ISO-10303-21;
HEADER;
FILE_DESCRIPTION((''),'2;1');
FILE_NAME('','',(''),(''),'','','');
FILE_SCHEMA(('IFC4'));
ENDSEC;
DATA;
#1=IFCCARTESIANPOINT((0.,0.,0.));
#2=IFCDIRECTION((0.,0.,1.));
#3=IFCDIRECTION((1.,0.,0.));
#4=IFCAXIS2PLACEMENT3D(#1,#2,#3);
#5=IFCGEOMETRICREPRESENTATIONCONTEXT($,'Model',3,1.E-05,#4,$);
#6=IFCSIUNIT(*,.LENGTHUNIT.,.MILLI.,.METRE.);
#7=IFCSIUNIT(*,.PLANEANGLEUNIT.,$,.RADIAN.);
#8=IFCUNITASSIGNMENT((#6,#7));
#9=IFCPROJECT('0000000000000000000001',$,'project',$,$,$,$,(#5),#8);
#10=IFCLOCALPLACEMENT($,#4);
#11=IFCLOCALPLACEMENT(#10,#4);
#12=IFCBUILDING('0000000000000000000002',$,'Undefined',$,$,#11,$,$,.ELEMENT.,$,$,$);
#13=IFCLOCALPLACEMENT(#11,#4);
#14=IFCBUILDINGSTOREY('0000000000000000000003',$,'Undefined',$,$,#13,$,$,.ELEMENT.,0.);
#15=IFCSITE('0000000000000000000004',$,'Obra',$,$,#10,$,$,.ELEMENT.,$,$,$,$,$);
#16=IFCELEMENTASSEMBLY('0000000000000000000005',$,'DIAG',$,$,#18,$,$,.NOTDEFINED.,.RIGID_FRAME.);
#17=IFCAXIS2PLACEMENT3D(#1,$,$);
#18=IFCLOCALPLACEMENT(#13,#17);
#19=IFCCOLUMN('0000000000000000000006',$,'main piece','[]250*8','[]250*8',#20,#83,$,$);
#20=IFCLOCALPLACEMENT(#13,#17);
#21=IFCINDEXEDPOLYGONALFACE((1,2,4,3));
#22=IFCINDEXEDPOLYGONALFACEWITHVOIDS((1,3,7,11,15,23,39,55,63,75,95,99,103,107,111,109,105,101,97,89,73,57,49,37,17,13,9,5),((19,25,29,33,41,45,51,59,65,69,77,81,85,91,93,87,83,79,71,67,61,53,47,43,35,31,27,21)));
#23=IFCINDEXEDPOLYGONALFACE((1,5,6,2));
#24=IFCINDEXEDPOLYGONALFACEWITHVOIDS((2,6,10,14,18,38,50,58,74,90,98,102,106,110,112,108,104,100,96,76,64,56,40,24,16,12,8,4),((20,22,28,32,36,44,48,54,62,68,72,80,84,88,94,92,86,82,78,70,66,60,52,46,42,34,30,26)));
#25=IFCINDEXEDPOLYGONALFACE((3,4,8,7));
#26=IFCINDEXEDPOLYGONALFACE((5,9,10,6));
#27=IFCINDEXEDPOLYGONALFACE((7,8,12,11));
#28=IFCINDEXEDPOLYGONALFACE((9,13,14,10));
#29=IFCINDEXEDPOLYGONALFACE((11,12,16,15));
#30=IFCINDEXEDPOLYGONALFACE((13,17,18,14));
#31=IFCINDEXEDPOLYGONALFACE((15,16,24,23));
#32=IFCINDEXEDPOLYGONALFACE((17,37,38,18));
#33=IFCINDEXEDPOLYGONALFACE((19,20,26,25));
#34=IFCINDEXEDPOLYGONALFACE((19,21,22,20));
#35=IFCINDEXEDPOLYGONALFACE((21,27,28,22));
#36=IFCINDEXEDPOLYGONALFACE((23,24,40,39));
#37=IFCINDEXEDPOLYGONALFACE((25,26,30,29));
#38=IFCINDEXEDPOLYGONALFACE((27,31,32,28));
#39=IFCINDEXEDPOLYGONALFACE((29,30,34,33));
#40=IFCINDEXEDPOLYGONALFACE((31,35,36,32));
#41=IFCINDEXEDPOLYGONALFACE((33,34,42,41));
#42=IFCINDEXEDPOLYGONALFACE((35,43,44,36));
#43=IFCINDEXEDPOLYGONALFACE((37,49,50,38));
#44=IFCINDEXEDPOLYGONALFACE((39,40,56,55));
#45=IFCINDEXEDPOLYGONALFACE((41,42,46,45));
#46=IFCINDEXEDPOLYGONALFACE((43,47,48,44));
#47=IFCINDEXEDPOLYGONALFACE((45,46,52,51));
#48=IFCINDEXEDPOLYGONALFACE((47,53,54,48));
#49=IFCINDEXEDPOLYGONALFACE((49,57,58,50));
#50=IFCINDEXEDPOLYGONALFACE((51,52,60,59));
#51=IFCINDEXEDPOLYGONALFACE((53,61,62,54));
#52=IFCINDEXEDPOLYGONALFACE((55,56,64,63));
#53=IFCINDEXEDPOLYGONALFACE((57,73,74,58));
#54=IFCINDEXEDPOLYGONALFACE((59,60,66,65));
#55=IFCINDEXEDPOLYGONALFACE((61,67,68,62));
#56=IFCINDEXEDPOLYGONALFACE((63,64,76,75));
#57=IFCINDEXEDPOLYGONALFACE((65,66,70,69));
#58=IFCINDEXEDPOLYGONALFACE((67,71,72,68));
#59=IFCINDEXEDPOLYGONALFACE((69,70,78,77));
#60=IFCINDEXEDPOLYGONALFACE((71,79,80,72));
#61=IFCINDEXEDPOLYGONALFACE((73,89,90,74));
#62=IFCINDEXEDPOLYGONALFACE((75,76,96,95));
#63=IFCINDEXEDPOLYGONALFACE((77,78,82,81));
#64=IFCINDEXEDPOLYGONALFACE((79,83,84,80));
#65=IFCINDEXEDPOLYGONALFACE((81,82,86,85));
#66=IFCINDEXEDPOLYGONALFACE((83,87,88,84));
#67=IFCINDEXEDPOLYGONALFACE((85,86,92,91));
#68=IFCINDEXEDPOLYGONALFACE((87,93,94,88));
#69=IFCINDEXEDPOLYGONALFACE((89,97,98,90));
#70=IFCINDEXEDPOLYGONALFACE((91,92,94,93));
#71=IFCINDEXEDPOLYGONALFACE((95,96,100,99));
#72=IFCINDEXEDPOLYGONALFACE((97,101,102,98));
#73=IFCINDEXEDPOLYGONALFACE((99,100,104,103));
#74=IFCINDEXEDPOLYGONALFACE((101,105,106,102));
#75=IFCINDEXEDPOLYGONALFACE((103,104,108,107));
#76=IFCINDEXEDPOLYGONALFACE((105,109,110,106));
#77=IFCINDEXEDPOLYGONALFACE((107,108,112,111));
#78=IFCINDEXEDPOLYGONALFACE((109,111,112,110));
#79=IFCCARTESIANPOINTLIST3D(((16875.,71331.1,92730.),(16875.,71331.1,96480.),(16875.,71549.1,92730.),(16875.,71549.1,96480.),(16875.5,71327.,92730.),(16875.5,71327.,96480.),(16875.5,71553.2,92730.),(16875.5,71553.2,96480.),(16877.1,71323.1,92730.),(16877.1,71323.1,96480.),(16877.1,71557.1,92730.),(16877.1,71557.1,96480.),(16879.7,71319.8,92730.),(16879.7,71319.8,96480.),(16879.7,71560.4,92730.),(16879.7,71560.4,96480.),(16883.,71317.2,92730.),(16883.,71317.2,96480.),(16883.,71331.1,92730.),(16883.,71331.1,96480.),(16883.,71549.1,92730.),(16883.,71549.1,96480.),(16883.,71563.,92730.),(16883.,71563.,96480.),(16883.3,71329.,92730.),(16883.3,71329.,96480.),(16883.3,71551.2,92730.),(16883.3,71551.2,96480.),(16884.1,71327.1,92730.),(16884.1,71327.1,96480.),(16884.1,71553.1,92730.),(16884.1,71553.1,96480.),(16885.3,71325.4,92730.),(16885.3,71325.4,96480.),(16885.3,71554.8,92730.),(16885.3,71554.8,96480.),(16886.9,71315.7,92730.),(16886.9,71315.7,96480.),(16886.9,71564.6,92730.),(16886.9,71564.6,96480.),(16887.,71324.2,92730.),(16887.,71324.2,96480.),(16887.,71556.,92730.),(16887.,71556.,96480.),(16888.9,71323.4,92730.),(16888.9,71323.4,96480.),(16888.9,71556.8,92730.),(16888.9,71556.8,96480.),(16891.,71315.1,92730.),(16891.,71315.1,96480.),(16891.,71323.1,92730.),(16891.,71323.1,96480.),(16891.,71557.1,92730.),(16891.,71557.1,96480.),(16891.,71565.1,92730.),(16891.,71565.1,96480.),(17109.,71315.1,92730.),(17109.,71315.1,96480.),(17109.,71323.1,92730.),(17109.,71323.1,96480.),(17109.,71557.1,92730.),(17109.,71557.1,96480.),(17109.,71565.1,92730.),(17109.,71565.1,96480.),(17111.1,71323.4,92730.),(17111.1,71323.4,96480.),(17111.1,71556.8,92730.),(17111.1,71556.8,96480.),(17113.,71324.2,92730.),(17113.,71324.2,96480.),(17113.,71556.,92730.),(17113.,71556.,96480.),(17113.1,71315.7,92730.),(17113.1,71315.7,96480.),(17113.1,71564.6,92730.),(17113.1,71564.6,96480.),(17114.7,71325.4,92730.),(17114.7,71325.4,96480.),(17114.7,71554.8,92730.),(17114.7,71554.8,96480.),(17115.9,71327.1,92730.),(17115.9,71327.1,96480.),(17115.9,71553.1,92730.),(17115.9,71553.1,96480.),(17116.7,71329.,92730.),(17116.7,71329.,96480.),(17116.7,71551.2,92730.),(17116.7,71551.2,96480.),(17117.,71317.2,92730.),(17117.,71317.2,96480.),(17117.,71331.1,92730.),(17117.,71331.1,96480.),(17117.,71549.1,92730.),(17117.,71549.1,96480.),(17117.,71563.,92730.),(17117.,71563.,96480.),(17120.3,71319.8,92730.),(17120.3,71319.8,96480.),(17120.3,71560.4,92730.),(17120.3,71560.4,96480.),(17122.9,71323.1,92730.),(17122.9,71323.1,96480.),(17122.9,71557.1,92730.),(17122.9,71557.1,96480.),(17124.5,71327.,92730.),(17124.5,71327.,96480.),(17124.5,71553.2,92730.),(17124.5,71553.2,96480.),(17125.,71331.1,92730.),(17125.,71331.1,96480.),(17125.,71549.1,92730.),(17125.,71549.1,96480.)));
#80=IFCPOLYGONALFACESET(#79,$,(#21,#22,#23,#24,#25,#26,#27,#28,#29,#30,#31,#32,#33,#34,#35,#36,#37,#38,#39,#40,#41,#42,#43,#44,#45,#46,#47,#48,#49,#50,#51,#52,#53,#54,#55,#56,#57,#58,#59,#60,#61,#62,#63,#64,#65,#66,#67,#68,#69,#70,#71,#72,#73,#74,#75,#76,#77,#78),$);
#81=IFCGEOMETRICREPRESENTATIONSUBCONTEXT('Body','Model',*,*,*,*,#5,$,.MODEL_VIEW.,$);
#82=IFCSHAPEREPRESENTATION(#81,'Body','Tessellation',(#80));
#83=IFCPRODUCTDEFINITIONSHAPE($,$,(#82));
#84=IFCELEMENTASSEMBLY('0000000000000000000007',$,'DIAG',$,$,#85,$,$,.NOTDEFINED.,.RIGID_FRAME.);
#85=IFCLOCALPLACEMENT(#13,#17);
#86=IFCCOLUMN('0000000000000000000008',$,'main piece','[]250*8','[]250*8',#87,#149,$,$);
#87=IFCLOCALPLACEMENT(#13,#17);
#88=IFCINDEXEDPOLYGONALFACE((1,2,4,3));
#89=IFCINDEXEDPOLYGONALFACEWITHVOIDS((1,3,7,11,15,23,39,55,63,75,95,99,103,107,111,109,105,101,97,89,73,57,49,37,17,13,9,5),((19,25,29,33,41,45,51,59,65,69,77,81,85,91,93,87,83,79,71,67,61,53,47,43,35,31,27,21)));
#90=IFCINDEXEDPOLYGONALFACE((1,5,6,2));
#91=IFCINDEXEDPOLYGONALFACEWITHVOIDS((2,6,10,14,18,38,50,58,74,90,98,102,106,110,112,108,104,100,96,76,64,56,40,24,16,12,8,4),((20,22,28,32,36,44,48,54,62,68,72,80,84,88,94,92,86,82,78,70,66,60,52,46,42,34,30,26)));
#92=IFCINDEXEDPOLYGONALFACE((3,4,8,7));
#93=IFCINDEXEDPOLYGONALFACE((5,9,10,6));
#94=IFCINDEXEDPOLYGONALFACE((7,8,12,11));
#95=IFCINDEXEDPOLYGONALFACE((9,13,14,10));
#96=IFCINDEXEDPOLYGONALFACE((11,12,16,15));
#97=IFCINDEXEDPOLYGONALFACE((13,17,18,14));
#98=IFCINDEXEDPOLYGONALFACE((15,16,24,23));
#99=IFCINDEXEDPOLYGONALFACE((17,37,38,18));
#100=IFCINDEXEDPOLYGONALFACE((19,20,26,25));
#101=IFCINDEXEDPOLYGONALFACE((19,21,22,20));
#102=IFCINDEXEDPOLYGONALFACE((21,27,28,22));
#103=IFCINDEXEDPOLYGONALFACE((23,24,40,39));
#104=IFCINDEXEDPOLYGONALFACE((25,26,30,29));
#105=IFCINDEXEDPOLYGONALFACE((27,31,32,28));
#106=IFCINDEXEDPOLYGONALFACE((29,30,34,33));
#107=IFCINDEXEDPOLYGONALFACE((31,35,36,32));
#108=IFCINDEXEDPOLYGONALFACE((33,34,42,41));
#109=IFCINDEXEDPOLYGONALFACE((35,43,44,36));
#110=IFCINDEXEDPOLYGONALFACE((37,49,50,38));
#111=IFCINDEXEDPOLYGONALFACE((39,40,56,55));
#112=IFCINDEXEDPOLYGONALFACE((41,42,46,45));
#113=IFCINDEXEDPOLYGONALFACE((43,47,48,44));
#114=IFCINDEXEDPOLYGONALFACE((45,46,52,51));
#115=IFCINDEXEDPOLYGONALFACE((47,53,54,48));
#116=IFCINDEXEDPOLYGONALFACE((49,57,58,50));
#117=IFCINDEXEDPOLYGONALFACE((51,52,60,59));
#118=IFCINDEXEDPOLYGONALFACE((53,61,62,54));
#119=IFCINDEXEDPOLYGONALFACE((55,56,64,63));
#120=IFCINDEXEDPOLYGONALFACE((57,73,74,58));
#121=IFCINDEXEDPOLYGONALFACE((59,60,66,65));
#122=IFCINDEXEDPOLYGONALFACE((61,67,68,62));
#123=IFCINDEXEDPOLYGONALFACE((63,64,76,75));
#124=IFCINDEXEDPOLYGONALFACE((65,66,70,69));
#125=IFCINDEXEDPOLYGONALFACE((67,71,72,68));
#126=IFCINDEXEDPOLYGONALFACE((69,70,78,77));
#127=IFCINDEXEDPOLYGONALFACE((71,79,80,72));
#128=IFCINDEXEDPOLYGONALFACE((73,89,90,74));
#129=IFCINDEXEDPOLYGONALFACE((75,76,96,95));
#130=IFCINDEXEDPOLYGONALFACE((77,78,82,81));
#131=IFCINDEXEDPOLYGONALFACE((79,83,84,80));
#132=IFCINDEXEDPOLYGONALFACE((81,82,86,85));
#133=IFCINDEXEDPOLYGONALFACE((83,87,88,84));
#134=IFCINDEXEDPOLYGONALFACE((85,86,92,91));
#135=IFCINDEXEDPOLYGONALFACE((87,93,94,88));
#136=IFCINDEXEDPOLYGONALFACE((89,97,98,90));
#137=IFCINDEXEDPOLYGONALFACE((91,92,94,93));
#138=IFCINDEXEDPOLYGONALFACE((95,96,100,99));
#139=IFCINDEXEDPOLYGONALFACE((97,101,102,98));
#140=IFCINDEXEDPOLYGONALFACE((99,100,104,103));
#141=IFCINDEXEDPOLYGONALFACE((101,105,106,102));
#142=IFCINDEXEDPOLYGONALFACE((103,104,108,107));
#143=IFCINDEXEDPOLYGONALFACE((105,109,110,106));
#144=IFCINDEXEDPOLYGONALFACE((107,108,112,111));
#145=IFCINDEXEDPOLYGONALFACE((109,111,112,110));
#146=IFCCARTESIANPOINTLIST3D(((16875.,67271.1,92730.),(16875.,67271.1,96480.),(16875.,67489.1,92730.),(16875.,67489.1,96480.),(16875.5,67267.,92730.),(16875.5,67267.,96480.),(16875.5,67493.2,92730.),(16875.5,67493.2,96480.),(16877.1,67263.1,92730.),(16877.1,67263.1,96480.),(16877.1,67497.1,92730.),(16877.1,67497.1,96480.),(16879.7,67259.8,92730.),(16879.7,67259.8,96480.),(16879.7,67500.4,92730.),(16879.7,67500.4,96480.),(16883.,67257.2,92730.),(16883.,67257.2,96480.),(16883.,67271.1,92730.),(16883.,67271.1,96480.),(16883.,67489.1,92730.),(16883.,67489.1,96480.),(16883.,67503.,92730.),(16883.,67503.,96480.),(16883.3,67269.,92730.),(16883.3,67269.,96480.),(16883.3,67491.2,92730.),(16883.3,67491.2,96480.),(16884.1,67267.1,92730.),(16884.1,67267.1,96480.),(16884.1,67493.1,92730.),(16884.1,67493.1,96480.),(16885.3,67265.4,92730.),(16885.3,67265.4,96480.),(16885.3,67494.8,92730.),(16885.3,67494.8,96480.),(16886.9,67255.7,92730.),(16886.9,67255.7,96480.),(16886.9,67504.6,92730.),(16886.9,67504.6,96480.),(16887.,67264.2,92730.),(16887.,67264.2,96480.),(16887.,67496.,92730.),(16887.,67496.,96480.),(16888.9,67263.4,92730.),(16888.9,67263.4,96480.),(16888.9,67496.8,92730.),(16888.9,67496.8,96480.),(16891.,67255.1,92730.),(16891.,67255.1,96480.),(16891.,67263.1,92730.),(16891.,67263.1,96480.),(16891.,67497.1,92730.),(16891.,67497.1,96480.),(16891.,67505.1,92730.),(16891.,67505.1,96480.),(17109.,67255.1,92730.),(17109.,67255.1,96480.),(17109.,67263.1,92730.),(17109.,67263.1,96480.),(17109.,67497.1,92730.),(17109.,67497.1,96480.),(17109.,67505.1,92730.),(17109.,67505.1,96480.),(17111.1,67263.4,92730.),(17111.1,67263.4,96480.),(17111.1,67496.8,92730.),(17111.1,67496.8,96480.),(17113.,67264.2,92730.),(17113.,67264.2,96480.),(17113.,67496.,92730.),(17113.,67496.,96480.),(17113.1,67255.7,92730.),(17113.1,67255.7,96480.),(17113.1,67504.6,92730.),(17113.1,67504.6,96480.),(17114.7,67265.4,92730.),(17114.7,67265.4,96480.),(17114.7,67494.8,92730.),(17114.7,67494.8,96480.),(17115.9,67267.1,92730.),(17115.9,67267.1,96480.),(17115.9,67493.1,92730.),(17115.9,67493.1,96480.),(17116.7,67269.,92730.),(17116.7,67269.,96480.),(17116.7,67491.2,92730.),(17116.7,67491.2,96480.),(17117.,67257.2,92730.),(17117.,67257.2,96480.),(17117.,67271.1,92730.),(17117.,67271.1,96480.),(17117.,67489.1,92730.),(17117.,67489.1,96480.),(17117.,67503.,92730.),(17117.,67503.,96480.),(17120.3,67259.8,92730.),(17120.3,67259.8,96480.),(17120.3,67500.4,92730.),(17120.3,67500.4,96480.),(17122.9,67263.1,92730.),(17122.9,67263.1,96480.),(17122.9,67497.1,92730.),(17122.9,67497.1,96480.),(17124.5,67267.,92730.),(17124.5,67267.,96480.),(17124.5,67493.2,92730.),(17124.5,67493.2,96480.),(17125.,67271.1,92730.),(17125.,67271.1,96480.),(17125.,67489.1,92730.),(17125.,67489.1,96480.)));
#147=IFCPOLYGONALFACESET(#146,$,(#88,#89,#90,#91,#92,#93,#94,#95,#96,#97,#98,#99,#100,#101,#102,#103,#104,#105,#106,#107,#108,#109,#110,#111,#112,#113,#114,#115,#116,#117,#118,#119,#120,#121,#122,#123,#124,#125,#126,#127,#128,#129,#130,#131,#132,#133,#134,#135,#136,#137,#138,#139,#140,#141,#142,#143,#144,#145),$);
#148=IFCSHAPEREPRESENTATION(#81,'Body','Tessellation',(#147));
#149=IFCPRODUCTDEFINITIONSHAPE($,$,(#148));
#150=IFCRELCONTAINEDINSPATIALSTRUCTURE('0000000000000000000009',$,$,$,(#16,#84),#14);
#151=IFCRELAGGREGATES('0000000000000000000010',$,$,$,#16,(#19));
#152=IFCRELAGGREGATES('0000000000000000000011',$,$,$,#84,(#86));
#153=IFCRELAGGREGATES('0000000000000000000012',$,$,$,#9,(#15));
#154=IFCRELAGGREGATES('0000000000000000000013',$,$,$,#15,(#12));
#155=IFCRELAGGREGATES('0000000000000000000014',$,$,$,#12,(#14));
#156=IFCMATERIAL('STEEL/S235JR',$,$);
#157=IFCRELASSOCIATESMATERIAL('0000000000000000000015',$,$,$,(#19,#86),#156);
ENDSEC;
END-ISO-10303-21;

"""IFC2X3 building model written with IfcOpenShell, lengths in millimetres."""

from ifc_helpers import new_model, si_unit, frame, origin_with_axes, origin_2d_with_axis, place, context, subcontext, project, spatial, hollow_rectangle, extrude, material, element, aggregate, save


model = new_model("IFC2X3")

# Units and contexts
model_context = context("Model", 3, precision=1e-05, world=origin_with_axes())
body_context = subcontext(model_context, "Body", "Model", "MODEL_VIEW")
ifc_project = project(units=[si_unit("LENGTHUNIT", "METRE", prefix="MILLI"), si_unit("PLANEANGLEUNIT", "RADIAN")], contexts=[model_context])

# Site, building, storey
site_placement = place(None, origin_with_axes())
site = spatial("IfcSite", under=ifc_project, at=site_placement, Name="Obra", CompositionType="ELEMENT")
building_placement = place(site_placement, origin_with_axes())
building = spatial("IfcBuilding", under=site, at=building_placement, Name="Undefined", CompositionType="ELEMENT")
storey_placement = place(building_placement, origin_with_axes())
storey = spatial("IfcBuildingStorey", under=building, at=storey_placement, Name="Undefined", CompositionType="ELEMENT", Elevation=0.0)

# Element assemblies, columns
ifc_material = material(Name="STEEL/S235JR")
assembly_1_placement = place(storey_placement, origin_with_axes())
assembly_1 = element("IfcElementAssembly", 1, at=assembly_1_placement, inside=storey, Name="DIAG", AssemblyPlace="NOTDEFINED", PredefinedType="RIGID_FRAME")
column_1_placement = place(assembly_1_placement, frame((17000.0, 71440.1, 92730.0), z_axis=(0.0, 0.0, 1.0), x_axis=(-1.0, 0.0, 0.0)))
column_1 = element("IfcColumn", 2, at=column_1_placement, material=ifc_material, Name="main piece", Description="[]250*8", ObjectType="[]250*8", context=body_context, shape_type="SweptSolid", body=[
    extrude(hollow_rectangle(XDim=250.0, YDim=250.0, WallThickness=8.0, InnerFilletRadius=8.0, OuterFilletRadius=16.0, at=origin_2d_with_axis()), frame((0.0, 0.0, 3750.0), z_axis=(0.0, 0.0, -1.0), x_axis=(0.0, 1.0, 0.0)), (0.0, 0.0, 1.0), 3750.0),
])
aggregate(assembly_1, [column_1])
assembly_2_placement = place(storey_placement, origin_with_axes())
assembly_2 = element("IfcElementAssembly", 3, at=assembly_2_placement, inside=storey, Name="DIAG", AssemblyPlace="NOTDEFINED", PredefinedType="RIGID_FRAME")
column_2_placement = place(assembly_2_placement, frame((17000.0, 67380.1, 92730.0), z_axis=(0.0, 0.0, 1.0), x_axis=(-1.0, 0.0, 0.0)))
column_2 = element("IfcColumn", 4, at=column_2_placement, material=ifc_material, Name="main piece", Description="[]250*8", ObjectType="[]250*8", context=body_context, shape_type="SweptSolid", body=[
    extrude(hollow_rectangle(XDim=250.0, YDim=250.0, WallThickness=8.0, InnerFilletRadius=8.0, OuterFilletRadius=16.0, at=origin_2d_with_axis()), frame((0.0, 0.0, 3750.0), z_axis=(0.0, 0.0, -1.0), x_axis=(0.0, 1.0, 0.0)), (0.0, 0.0, 1.0), 3750.0),
])
aggregate(assembly_2, [column_2])

save(model, "model.ifc")
